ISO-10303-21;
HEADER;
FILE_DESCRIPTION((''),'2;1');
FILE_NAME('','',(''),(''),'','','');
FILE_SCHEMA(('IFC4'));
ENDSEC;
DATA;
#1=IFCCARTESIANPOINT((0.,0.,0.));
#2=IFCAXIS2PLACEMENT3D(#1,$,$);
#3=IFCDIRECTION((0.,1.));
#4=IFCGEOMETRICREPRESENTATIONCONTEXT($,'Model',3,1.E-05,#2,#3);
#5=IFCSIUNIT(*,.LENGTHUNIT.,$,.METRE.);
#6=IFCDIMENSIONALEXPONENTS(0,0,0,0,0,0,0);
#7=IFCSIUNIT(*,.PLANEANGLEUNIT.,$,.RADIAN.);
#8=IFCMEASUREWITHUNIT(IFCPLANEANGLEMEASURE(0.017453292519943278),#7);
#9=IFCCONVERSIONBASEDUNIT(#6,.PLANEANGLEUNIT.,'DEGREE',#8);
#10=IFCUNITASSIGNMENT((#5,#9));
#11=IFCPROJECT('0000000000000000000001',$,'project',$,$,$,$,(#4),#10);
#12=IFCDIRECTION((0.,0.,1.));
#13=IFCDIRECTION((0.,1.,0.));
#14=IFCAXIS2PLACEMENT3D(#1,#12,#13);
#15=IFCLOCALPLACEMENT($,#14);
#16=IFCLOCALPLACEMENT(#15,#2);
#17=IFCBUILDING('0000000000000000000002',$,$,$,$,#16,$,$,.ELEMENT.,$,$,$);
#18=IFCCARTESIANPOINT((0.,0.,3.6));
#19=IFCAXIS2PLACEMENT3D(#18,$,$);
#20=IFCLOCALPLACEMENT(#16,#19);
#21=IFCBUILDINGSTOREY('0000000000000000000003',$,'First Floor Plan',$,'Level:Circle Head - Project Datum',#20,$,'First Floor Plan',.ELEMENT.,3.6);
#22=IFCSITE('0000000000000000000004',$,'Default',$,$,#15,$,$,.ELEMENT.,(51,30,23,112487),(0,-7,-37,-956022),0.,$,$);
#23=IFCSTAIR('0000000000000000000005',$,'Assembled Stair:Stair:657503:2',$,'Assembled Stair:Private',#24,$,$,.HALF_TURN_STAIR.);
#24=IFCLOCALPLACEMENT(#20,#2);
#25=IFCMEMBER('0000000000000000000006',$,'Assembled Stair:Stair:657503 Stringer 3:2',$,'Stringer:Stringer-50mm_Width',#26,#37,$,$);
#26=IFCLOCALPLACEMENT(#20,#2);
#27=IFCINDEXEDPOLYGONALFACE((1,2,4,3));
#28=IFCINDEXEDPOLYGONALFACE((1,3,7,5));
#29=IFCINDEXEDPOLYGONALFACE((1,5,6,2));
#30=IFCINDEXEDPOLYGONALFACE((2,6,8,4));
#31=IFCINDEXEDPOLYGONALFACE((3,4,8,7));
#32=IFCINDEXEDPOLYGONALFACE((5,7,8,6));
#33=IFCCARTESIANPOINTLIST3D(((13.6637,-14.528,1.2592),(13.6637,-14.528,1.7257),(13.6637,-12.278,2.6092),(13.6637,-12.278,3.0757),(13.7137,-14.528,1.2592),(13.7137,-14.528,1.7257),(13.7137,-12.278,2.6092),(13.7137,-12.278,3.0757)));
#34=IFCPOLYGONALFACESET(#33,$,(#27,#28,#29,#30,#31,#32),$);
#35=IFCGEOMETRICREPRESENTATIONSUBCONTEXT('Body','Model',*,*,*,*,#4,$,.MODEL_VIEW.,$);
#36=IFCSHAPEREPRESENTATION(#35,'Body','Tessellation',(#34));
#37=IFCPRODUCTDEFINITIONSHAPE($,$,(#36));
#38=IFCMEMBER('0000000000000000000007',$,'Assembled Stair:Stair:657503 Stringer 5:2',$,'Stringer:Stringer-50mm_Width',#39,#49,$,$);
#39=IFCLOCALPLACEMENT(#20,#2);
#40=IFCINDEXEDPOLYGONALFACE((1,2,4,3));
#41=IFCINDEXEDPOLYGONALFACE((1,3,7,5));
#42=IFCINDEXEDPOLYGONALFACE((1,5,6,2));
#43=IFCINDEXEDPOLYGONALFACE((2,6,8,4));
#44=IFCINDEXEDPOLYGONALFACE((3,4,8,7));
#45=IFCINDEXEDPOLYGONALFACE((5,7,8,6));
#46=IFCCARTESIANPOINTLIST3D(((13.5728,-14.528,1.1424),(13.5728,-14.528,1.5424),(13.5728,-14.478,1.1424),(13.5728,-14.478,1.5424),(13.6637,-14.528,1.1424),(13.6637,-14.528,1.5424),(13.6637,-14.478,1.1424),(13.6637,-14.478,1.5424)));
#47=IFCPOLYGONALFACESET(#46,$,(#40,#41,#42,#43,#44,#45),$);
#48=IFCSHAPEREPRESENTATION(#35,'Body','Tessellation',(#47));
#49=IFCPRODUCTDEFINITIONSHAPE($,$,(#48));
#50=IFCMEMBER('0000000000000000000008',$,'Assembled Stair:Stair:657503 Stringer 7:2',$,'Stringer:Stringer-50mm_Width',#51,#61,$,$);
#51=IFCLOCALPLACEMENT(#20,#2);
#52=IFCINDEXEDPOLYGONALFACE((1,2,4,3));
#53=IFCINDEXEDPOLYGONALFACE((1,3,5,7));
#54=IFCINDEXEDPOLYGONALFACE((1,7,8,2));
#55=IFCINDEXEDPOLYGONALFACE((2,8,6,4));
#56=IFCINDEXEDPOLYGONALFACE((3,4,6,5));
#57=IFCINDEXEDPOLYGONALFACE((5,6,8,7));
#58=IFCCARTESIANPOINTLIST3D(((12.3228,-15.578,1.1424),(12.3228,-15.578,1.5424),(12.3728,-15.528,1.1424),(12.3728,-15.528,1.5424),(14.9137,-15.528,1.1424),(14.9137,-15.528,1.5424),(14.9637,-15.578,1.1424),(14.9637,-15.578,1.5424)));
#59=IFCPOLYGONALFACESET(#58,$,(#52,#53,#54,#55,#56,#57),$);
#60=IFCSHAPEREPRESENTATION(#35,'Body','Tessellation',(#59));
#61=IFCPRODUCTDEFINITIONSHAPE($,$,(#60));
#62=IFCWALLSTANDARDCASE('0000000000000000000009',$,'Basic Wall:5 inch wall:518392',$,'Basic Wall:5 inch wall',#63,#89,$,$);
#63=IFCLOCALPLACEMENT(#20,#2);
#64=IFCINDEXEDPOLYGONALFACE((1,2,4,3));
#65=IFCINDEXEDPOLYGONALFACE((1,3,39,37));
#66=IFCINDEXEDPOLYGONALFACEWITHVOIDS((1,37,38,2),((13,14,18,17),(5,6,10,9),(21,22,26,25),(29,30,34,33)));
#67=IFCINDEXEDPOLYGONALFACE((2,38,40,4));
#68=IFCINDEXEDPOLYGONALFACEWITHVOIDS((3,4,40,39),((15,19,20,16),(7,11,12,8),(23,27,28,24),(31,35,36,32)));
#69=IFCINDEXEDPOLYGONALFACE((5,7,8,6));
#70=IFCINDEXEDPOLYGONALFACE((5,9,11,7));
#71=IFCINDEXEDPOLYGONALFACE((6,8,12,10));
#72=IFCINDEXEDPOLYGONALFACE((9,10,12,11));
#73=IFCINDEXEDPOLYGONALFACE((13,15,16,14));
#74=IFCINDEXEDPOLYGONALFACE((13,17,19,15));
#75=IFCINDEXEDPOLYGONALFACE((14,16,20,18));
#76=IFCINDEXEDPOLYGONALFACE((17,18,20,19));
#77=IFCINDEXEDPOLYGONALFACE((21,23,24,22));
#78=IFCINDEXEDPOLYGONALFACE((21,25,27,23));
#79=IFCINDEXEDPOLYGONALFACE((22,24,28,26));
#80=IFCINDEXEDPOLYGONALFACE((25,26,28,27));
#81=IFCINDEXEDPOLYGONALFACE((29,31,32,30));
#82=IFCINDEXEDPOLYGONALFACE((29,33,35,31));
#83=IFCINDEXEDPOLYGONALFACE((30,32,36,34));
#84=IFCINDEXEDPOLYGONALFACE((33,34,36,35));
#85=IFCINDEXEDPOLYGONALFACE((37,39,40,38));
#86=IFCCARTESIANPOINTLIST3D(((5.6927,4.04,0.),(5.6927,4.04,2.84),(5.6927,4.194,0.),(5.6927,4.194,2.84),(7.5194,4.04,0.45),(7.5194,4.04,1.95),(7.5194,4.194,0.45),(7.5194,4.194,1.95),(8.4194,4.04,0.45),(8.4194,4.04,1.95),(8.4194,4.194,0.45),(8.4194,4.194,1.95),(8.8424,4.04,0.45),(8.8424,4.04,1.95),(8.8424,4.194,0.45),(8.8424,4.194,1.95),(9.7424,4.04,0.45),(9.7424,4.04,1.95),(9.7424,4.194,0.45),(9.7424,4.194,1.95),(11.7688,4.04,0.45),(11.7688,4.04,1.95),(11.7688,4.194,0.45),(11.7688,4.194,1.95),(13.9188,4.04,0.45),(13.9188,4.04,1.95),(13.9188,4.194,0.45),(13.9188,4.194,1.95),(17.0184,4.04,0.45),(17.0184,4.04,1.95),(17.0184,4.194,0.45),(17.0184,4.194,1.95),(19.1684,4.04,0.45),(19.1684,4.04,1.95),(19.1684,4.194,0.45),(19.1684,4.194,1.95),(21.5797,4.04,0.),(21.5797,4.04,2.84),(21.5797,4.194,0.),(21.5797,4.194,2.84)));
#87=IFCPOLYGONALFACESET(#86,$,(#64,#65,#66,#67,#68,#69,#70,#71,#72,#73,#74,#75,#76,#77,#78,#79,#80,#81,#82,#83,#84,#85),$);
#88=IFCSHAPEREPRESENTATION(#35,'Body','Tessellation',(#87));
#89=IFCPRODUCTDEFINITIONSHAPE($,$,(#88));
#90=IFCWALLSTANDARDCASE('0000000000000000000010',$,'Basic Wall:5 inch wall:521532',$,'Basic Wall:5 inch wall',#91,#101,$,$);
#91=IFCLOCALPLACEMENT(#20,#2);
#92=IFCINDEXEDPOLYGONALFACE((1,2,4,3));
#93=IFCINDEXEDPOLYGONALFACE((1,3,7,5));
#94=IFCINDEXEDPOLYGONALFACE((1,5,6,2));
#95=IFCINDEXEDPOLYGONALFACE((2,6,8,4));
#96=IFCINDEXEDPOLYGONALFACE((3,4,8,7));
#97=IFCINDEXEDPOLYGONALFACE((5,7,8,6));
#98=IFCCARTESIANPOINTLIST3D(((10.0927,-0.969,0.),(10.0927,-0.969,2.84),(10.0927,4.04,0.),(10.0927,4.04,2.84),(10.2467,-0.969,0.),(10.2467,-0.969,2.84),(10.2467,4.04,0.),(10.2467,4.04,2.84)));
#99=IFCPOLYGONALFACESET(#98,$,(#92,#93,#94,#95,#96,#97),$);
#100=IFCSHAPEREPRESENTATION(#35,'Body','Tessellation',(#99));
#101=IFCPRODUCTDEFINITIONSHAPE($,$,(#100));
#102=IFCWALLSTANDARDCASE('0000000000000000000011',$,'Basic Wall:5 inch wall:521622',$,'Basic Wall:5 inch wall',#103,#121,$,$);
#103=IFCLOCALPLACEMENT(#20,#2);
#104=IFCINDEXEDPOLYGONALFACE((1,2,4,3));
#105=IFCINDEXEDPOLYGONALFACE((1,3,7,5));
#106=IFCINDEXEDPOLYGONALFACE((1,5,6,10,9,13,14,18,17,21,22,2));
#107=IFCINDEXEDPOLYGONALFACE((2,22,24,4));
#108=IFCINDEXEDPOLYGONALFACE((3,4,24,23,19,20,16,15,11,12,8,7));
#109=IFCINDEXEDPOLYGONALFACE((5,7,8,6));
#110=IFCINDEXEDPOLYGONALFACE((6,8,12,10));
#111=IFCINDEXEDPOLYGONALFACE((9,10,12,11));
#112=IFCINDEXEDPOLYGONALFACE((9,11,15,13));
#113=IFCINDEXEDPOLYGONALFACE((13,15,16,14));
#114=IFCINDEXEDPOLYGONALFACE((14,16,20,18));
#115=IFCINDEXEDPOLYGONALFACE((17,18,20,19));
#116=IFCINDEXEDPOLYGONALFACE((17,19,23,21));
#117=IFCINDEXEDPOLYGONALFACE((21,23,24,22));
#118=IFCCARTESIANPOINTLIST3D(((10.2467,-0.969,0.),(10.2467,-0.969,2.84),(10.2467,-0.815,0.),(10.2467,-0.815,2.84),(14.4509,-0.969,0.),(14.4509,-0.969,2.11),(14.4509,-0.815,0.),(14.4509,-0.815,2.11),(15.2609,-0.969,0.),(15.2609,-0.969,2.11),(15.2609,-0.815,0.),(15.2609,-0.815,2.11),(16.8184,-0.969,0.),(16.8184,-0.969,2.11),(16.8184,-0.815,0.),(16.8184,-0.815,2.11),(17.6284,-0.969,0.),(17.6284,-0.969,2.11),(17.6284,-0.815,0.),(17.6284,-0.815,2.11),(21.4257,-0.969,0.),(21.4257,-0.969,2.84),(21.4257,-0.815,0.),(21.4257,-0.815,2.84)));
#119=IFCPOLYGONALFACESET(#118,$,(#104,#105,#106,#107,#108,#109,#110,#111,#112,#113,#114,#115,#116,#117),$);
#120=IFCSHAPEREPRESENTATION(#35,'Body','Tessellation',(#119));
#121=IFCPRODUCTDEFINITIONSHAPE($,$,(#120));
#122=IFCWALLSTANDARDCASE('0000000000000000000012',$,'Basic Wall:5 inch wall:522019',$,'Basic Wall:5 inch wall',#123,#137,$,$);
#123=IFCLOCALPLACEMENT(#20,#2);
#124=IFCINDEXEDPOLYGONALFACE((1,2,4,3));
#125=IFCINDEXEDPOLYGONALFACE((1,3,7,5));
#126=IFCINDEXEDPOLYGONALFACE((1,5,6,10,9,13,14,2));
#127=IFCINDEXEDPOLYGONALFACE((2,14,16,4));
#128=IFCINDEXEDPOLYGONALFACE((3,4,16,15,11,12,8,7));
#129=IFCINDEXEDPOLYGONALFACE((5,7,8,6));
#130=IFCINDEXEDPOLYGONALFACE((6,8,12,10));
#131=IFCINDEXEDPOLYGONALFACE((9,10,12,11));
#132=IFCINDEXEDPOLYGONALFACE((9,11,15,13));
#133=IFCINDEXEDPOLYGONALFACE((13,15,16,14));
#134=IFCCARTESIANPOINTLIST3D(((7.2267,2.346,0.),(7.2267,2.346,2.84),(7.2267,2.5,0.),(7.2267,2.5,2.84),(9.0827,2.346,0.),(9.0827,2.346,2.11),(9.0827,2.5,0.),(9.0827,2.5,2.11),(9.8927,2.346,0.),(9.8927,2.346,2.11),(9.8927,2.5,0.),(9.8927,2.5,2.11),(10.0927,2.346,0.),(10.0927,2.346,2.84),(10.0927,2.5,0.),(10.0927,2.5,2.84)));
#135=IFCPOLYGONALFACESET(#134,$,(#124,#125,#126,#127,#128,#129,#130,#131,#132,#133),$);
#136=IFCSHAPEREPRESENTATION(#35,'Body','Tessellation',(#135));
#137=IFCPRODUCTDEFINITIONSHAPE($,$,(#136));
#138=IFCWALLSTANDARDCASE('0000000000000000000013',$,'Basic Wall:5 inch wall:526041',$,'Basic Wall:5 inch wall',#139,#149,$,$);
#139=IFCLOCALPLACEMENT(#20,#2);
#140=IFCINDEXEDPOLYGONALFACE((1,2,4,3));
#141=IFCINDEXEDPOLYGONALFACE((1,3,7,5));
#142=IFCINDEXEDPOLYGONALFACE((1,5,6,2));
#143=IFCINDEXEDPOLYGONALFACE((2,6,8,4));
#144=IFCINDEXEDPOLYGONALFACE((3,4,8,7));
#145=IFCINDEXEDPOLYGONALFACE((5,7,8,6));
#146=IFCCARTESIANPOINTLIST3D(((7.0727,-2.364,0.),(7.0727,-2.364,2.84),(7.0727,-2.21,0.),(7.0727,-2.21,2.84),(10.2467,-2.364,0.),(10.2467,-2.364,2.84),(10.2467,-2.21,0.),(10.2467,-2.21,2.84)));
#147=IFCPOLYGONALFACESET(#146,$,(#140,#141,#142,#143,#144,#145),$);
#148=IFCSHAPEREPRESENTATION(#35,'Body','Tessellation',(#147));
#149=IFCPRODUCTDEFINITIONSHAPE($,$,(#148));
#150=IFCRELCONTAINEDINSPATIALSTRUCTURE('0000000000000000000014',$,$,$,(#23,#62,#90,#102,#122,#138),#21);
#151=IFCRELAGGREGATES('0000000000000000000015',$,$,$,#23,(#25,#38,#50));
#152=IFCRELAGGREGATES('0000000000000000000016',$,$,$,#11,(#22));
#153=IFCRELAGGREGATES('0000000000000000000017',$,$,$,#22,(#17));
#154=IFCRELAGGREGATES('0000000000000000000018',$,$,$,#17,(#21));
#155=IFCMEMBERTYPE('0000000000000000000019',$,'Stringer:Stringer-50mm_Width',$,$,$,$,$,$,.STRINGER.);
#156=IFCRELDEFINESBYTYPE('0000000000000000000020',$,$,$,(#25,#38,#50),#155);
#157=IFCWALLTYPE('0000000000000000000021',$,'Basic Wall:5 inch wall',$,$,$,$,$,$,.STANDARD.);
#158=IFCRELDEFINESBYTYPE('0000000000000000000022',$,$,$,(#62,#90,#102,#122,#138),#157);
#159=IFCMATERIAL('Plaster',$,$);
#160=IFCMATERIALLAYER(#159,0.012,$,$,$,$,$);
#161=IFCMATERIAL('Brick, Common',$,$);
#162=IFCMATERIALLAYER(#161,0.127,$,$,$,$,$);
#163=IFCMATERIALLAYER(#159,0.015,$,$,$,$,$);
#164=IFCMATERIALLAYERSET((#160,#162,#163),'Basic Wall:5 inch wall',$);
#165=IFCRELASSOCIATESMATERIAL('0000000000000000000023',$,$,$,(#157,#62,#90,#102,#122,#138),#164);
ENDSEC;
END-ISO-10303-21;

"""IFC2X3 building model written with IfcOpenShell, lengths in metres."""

from ifc_helpers import new_model, entity, si_unit, converted_unit, direction, frame, frame_2d, origin, place, context, subcontext, project, spatial, polyline, rectangle, outline, extrude, material, layer, layer_set, layer_usage, type_object, element, aggregate, save


model = new_model("IFC2X3")

# Units and contexts
model_context = context("Model", 3, precision=1e-05, world=origin(), true_north=direction((0.0, 1.0)))
body_context = subcontext(model_context, "Body", "Model", "MODEL_VIEW")
ifc_project = project(units=[si_unit("LENGTHUNIT", "METRE"), converted_unit("PLANEANGLEUNIT", "DEGREE", entity("IfcPlaneAngleMeasure", 0.017453292519943278), si_unit("PLANEANGLEUNIT", "RADIAN"), dimensions=[0, 0, 0, 0, 0, 0, 0])], contexts=[model_context])

# Site, building, storey
site_placement = place(None, frame((0.0, 0.0, 0.0), z_axis=(0.0, 0.0, 1.0), x_axis=(0.0, 1.0, 0.0)))
site = spatial("IfcSite", under=ifc_project, at=site_placement, Name="Default", CompositionType="ELEMENT", RefLatitude=(51, 30, 23, 112487), RefLongitude=(0, -7, -37, -956022), RefElevation=0.0)
building_placement = place(site_placement, origin())
building = spatial("IfcBuilding", under=site, at=building_placement, CompositionType="ELEMENT")
storey_placement = place(building_placement, frame((0.0, 0.0, 3.6)))
storey = spatial("IfcBuildingStorey", under=building, at=storey_placement, Name="First Floor Plan", ObjectType="Level:Circle Head - Project Datum", LongName="First Floor Plan", CompositionType="ELEMENT", Elevation=3.6)

# Stair, members
stair_placement = place(storey_placement, origin())
stair = element("IfcStair", 1, at=stair_placement, inside=storey, Name="Assembled Stair:Stair:657503:2", ObjectType="Assembled Stair:Private", ShapeType="HALF_TURN_STAIR")
member_type = type_object("IfcMemberType", Name="Stringer:Stringer-50mm_Width", PredefinedType="STRINGER")
member_1_placement = place(stair_placement, origin())
member_1 = element("IfcMember", 2, at=member_1_placement, type_object=member_type, Name="Assembled Stair:Stair:657503 Stringer 3:2", ObjectType="Stringer:Stringer-50mm_Width", context=body_context, shape_type="SweptSolid", body=[
    extrude(outline(polyline([(-1.432, -0.2), (1.192, -0.2), (1.432, 0.2), (-1.192, 0.2), (-1.432, -0.2)])), frame((13.6637, -13.403, 2.1675), z_axis=(1.0, 0.0, 0.0), x_axis=(0.0, 0.857493, 0.514496)), (0.0, 0.0, 1.0), 0.05),
])
member_2_placement = place(stair_placement, origin())
member_2 = element("IfcMember", 3, at=member_2_placement, type_object=member_type, Name="Assembled Stair:Stair:657503 Stringer 5:2", ObjectType="Stringer:Stringer-50mm_Width", context=body_context, shape_type="SweptSolid", body=[
    extrude(rectangle(XDim=0.0908, YDim=0.05, at=frame_2d((0.0, 0.0), x_axis=(1.0, 0.0))), frame((13.6183, -14.503, 1.1424), z_axis=(0.0, 0.0, 1.0), x_axis=(-1.0, 0.0, 0.0)), (0.0, 0.0, 1.0), 0.4),
])
member_3_placement = place(stair_placement, origin())
member_3 = element("IfcMember", 4, at=member_3_placement, type_object=member_type, Name="Assembled Stair:Stair:657503 Stringer 7:2", ObjectType="Stringer:Stringer-50mm_Width", context=body_context, shape_type="SweptSolid", body=[
    extrude(outline(polyline([(-1.3204, -0.025), (1.3204, -0.025), (1.2704, 0.025), (-1.2704, 0.025), (-1.3204, -0.025)])), frame((13.6433, -15.553, 1.1424)), (0.0, 0.0, 1.0), 0.4),
])

# Wall, openings
ifc_material_1 = material(Name="Plaster")
ifc_layer_1 = layer(ifc_material_1, 0.012)
ifc_material_2 = material(Name="Brick, Common")
ifc_layer_2 = layer(ifc_material_2, 0.127)
ifc_layer_3 = layer(ifc_material_1, 0.015)
ifc_layer_set_1 = layer_set([ifc_layer_1, ifc_layer_2, ifc_layer_3], Name="Basic Wall:5 inch wall")
ifc_layer_usage_1 = layer_usage(ifc_layer_set_1, "AXIS2", "NEGATIVE", 0.077)
wall_type = type_object("IfcWallType", Name="Basic Wall:5 inch wall", PredefinedType="STANDARD", material=ifc_layer_set_1)
wall_1_placement = place(storey_placement, frame((5.6927, 4.117, 0.0)))
wall_1 = element("IfcWallStandardCase", 5, at=wall_1_placement, inside=storey, type_object=wall_type, material=ifc_layer_usage_1, Name="Basic Wall:5 inch wall:518392", ObjectType="Basic Wall:5 inch wall", context=body_context, shape_type="SweptSolid", body=[
    extrude(rectangle(XDim=15.887, YDim=0.154, at=frame_2d((7.9435, 0.0), x_axis=(-1.0, 0.0))), origin(), (0.0, 0.0, 1.0), 2.84),
])
opening_1_placement = place(wall_1_placement, frame((1.8267, -0.077, 0.45)))
element("IfcOpeningElement", 6, at=opening_1_placement, cuts=wall_1, ObjectType="Opening", context=body_context, shape_type="SweptSolid", body=[
    extrude(rectangle(XDim=1.5, YDim=0.9, at=frame_2d((0.75, 0.45), x_axis=(-1.0, 0.0))), frame((0.0, 0.0, 0.0), z_axis=(0.0, 1.0, 0.0), x_axis=(0.0, 0.0, 1.0)), (0.0, 0.0, 1.0), 0.154),
])
opening_2_placement = place(wall_1_placement, frame((3.1497, -0.077, 0.45)))
element("IfcOpeningElement", 7, at=opening_2_placement, cuts=wall_1, ObjectType="Opening", context=body_context, shape_type="SweptSolid", body=[
    extrude(rectangle(XDim=1.5, YDim=0.9, at=frame_2d((0.75, 0.45), x_axis=(-1.0, 0.0))), frame((0.0, 0.0, 0.0), z_axis=(0.0, 1.0, 0.0), x_axis=(0.0, 0.0, 1.0)), (0.0, 0.0, 1.0), 0.154),
])
opening_3_placement = place(wall_1_placement, frame((6.0761, -0.077, 0.45)))
element("IfcOpeningElement", 8, at=opening_3_placement, cuts=wall_1, ObjectType="Opening", context=body_context, shape_type="SweptSolid", body=[
    extrude(rectangle(XDim=1.5, YDim=2.15, at=frame_2d((0.75, 1.075), x_axis=(-1.0, 0.0))), frame((0.0, 0.0, 0.0), z_axis=(0.0, 1.0, 0.0), x_axis=(0.0, 0.0, 1.0)), (0.0, 0.0, 1.0), 0.154),
])
opening_4_placement = place(wall_1_placement, frame((11.3257, -0.077, 0.45)))
element("IfcOpeningElement", 9, at=opening_4_placement, cuts=wall_1, ObjectType="Opening", context=body_context, shape_type="SweptSolid", body=[
    extrude(rectangle(XDim=1.5, YDim=2.15, at=frame_2d((0.75, 1.075), x_axis=(-1.0, 0.0))), frame((0.0, 0.0, 0.0), z_axis=(0.0, 1.0, 0.0), x_axis=(0.0, 0.0, 1.0)), (0.0, 0.0, 1.0), 0.154),
])

# Wall
ifc_layer_usage_2 = layer_usage(ifc_layer_set_1, "AXIS2", "NEGATIVE", 0.077)
wall_2_placement = place(storey_placement, frame((10.1697, 4.04, 0.0), z_axis=(0.0, 0.0, 1.0), x_axis=(0.0, -1.0, 0.0)))
element("IfcWallStandardCase", 10, at=wall_2_placement, inside=storey, type_object=wall_type, material=ifc_layer_usage_2, Name="Basic Wall:5 inch wall:521532", ObjectType="Basic Wall:5 inch wall", context=body_context, shape_type="SweptSolid", body=[
    extrude(rectangle(XDim=5.009, YDim=0.154, at=frame_2d((2.5045, 0.0), x_axis=(-1.0, 0.0))), origin(), (0.0, 0.0, 1.0), 2.84),
])

# Wall, openings
ifc_layer_usage_3 = layer_usage(ifc_layer_set_1, "AXIS2", "NEGATIVE", 0.077)
wall_3_placement = place(storey_placement, frame((10.2467, -0.892, 0.0)))
wall_3 = element("IfcWallStandardCase", 11, at=wall_3_placement, inside=storey, type_object=wall_type, material=ifc_layer_usage_3, Name="Basic Wall:5 inch wall:521622", ObjectType="Basic Wall:5 inch wall", context=body_context, shape_type="SweptSolid", body=[
    extrude(rectangle(XDim=11.179, YDim=0.154, at=frame_2d((5.5895, 0.0), x_axis=(-1.0, 0.0))), origin(), (0.0, 0.0, 1.0), 2.84),
])
opening_5_placement = place(wall_3_placement, frame((4.2043, -0.077, 0.0)))
element("IfcOpeningElement", 12, at=opening_5_placement, cuts=wall_3, ObjectType="Opening", context=body_context, shape_type="SweptSolid", body=[
    extrude(rectangle(XDim=2.11, YDim=0.81, at=frame_2d((1.055, 0.405), x_axis=(1.0, 0.0))), frame((0.0, 0.0, 0.0), z_axis=(0.0, 1.0, 0.0), x_axis=(0.0, 0.0, 1.0)), (0.0, 0.0, 1.0), 0.154),
])
opening_6_placement = place(wall_3_placement, frame((6.5717, -0.077, 0.0)))
element("IfcOpeningElement", 13, at=opening_6_placement, cuts=wall_3, ObjectType="Opening", context=body_context, shape_type="SweptSolid", body=[
    extrude(rectangle(XDim=2.11, YDim=0.81, at=frame_2d((1.055, 0.405), x_axis=(1.0, 0.0))), frame((0.0, 0.0, 0.0), z_axis=(0.0, 1.0, 0.0), x_axis=(0.0, 0.0, 1.0)), (0.0, 0.0, 1.0), 0.154),
])

# Wall, opening
ifc_layer_usage_4 = layer_usage(ifc_layer_set_1, "AXIS2", "NEGATIVE", 0.077)
wall_4_placement = place(storey_placement, frame((7.2267, 2.423, 0.0)))
wall_4 = element("IfcWallStandardCase", 14, at=wall_4_placement, inside=storey, type_object=wall_type, material=ifc_layer_usage_4, Name="Basic Wall:5 inch wall:522019", ObjectType="Basic Wall:5 inch wall", context=body_context, shape_type="SweptSolid", body=[
    extrude(rectangle(XDim=2.866, YDim=0.154, at=frame_2d((1.433, 0.0), x_axis=(1.0, 0.0))), origin(), (0.0, 0.0, 1.0), 2.84),
])
opening_7_placement = place(wall_4_placement, frame((1.856, -0.077, 0.0)))
element("IfcOpeningElement", 15, at=opening_7_placement, cuts=wall_4, ObjectType="Opening", context=body_context, shape_type="SweptSolid", body=[
    extrude(rectangle(XDim=2.11, YDim=0.81, at=frame_2d((1.055, 0.405), x_axis=(1.0, 0.0))), frame((0.0, 0.0, 0.0), z_axis=(0.0, 1.0, 0.0), x_axis=(0.0, 0.0, 1.0)), (0.0, 0.0, 1.0), 0.154),
])

# Wall
ifc_layer_usage_5 = layer_usage(ifc_layer_set_1, "AXIS2", "NEGATIVE", 0.077)
wall_5_placement = place(storey_placement, frame((7.0727, -2.287, 0.0)))
element("IfcWallStandardCase", 16, at=wall_5_placement, inside=storey, type_object=wall_type, material=ifc_layer_usage_5, Name="Basic Wall:5 inch wall:526041", ObjectType="Basic Wall:5 inch wall", context=body_context, shape_type="SweptSolid", body=[
    extrude(rectangle(XDim=3.174, YDim=0.154, at=frame_2d((1.587, 0.0), x_axis=(-1.0, 0.0))), origin(), (0.0, 0.0, 1.0), 2.84),
])

aggregate(stair, [member_1, member_2, member_3])

save(model, "model.ifc")
